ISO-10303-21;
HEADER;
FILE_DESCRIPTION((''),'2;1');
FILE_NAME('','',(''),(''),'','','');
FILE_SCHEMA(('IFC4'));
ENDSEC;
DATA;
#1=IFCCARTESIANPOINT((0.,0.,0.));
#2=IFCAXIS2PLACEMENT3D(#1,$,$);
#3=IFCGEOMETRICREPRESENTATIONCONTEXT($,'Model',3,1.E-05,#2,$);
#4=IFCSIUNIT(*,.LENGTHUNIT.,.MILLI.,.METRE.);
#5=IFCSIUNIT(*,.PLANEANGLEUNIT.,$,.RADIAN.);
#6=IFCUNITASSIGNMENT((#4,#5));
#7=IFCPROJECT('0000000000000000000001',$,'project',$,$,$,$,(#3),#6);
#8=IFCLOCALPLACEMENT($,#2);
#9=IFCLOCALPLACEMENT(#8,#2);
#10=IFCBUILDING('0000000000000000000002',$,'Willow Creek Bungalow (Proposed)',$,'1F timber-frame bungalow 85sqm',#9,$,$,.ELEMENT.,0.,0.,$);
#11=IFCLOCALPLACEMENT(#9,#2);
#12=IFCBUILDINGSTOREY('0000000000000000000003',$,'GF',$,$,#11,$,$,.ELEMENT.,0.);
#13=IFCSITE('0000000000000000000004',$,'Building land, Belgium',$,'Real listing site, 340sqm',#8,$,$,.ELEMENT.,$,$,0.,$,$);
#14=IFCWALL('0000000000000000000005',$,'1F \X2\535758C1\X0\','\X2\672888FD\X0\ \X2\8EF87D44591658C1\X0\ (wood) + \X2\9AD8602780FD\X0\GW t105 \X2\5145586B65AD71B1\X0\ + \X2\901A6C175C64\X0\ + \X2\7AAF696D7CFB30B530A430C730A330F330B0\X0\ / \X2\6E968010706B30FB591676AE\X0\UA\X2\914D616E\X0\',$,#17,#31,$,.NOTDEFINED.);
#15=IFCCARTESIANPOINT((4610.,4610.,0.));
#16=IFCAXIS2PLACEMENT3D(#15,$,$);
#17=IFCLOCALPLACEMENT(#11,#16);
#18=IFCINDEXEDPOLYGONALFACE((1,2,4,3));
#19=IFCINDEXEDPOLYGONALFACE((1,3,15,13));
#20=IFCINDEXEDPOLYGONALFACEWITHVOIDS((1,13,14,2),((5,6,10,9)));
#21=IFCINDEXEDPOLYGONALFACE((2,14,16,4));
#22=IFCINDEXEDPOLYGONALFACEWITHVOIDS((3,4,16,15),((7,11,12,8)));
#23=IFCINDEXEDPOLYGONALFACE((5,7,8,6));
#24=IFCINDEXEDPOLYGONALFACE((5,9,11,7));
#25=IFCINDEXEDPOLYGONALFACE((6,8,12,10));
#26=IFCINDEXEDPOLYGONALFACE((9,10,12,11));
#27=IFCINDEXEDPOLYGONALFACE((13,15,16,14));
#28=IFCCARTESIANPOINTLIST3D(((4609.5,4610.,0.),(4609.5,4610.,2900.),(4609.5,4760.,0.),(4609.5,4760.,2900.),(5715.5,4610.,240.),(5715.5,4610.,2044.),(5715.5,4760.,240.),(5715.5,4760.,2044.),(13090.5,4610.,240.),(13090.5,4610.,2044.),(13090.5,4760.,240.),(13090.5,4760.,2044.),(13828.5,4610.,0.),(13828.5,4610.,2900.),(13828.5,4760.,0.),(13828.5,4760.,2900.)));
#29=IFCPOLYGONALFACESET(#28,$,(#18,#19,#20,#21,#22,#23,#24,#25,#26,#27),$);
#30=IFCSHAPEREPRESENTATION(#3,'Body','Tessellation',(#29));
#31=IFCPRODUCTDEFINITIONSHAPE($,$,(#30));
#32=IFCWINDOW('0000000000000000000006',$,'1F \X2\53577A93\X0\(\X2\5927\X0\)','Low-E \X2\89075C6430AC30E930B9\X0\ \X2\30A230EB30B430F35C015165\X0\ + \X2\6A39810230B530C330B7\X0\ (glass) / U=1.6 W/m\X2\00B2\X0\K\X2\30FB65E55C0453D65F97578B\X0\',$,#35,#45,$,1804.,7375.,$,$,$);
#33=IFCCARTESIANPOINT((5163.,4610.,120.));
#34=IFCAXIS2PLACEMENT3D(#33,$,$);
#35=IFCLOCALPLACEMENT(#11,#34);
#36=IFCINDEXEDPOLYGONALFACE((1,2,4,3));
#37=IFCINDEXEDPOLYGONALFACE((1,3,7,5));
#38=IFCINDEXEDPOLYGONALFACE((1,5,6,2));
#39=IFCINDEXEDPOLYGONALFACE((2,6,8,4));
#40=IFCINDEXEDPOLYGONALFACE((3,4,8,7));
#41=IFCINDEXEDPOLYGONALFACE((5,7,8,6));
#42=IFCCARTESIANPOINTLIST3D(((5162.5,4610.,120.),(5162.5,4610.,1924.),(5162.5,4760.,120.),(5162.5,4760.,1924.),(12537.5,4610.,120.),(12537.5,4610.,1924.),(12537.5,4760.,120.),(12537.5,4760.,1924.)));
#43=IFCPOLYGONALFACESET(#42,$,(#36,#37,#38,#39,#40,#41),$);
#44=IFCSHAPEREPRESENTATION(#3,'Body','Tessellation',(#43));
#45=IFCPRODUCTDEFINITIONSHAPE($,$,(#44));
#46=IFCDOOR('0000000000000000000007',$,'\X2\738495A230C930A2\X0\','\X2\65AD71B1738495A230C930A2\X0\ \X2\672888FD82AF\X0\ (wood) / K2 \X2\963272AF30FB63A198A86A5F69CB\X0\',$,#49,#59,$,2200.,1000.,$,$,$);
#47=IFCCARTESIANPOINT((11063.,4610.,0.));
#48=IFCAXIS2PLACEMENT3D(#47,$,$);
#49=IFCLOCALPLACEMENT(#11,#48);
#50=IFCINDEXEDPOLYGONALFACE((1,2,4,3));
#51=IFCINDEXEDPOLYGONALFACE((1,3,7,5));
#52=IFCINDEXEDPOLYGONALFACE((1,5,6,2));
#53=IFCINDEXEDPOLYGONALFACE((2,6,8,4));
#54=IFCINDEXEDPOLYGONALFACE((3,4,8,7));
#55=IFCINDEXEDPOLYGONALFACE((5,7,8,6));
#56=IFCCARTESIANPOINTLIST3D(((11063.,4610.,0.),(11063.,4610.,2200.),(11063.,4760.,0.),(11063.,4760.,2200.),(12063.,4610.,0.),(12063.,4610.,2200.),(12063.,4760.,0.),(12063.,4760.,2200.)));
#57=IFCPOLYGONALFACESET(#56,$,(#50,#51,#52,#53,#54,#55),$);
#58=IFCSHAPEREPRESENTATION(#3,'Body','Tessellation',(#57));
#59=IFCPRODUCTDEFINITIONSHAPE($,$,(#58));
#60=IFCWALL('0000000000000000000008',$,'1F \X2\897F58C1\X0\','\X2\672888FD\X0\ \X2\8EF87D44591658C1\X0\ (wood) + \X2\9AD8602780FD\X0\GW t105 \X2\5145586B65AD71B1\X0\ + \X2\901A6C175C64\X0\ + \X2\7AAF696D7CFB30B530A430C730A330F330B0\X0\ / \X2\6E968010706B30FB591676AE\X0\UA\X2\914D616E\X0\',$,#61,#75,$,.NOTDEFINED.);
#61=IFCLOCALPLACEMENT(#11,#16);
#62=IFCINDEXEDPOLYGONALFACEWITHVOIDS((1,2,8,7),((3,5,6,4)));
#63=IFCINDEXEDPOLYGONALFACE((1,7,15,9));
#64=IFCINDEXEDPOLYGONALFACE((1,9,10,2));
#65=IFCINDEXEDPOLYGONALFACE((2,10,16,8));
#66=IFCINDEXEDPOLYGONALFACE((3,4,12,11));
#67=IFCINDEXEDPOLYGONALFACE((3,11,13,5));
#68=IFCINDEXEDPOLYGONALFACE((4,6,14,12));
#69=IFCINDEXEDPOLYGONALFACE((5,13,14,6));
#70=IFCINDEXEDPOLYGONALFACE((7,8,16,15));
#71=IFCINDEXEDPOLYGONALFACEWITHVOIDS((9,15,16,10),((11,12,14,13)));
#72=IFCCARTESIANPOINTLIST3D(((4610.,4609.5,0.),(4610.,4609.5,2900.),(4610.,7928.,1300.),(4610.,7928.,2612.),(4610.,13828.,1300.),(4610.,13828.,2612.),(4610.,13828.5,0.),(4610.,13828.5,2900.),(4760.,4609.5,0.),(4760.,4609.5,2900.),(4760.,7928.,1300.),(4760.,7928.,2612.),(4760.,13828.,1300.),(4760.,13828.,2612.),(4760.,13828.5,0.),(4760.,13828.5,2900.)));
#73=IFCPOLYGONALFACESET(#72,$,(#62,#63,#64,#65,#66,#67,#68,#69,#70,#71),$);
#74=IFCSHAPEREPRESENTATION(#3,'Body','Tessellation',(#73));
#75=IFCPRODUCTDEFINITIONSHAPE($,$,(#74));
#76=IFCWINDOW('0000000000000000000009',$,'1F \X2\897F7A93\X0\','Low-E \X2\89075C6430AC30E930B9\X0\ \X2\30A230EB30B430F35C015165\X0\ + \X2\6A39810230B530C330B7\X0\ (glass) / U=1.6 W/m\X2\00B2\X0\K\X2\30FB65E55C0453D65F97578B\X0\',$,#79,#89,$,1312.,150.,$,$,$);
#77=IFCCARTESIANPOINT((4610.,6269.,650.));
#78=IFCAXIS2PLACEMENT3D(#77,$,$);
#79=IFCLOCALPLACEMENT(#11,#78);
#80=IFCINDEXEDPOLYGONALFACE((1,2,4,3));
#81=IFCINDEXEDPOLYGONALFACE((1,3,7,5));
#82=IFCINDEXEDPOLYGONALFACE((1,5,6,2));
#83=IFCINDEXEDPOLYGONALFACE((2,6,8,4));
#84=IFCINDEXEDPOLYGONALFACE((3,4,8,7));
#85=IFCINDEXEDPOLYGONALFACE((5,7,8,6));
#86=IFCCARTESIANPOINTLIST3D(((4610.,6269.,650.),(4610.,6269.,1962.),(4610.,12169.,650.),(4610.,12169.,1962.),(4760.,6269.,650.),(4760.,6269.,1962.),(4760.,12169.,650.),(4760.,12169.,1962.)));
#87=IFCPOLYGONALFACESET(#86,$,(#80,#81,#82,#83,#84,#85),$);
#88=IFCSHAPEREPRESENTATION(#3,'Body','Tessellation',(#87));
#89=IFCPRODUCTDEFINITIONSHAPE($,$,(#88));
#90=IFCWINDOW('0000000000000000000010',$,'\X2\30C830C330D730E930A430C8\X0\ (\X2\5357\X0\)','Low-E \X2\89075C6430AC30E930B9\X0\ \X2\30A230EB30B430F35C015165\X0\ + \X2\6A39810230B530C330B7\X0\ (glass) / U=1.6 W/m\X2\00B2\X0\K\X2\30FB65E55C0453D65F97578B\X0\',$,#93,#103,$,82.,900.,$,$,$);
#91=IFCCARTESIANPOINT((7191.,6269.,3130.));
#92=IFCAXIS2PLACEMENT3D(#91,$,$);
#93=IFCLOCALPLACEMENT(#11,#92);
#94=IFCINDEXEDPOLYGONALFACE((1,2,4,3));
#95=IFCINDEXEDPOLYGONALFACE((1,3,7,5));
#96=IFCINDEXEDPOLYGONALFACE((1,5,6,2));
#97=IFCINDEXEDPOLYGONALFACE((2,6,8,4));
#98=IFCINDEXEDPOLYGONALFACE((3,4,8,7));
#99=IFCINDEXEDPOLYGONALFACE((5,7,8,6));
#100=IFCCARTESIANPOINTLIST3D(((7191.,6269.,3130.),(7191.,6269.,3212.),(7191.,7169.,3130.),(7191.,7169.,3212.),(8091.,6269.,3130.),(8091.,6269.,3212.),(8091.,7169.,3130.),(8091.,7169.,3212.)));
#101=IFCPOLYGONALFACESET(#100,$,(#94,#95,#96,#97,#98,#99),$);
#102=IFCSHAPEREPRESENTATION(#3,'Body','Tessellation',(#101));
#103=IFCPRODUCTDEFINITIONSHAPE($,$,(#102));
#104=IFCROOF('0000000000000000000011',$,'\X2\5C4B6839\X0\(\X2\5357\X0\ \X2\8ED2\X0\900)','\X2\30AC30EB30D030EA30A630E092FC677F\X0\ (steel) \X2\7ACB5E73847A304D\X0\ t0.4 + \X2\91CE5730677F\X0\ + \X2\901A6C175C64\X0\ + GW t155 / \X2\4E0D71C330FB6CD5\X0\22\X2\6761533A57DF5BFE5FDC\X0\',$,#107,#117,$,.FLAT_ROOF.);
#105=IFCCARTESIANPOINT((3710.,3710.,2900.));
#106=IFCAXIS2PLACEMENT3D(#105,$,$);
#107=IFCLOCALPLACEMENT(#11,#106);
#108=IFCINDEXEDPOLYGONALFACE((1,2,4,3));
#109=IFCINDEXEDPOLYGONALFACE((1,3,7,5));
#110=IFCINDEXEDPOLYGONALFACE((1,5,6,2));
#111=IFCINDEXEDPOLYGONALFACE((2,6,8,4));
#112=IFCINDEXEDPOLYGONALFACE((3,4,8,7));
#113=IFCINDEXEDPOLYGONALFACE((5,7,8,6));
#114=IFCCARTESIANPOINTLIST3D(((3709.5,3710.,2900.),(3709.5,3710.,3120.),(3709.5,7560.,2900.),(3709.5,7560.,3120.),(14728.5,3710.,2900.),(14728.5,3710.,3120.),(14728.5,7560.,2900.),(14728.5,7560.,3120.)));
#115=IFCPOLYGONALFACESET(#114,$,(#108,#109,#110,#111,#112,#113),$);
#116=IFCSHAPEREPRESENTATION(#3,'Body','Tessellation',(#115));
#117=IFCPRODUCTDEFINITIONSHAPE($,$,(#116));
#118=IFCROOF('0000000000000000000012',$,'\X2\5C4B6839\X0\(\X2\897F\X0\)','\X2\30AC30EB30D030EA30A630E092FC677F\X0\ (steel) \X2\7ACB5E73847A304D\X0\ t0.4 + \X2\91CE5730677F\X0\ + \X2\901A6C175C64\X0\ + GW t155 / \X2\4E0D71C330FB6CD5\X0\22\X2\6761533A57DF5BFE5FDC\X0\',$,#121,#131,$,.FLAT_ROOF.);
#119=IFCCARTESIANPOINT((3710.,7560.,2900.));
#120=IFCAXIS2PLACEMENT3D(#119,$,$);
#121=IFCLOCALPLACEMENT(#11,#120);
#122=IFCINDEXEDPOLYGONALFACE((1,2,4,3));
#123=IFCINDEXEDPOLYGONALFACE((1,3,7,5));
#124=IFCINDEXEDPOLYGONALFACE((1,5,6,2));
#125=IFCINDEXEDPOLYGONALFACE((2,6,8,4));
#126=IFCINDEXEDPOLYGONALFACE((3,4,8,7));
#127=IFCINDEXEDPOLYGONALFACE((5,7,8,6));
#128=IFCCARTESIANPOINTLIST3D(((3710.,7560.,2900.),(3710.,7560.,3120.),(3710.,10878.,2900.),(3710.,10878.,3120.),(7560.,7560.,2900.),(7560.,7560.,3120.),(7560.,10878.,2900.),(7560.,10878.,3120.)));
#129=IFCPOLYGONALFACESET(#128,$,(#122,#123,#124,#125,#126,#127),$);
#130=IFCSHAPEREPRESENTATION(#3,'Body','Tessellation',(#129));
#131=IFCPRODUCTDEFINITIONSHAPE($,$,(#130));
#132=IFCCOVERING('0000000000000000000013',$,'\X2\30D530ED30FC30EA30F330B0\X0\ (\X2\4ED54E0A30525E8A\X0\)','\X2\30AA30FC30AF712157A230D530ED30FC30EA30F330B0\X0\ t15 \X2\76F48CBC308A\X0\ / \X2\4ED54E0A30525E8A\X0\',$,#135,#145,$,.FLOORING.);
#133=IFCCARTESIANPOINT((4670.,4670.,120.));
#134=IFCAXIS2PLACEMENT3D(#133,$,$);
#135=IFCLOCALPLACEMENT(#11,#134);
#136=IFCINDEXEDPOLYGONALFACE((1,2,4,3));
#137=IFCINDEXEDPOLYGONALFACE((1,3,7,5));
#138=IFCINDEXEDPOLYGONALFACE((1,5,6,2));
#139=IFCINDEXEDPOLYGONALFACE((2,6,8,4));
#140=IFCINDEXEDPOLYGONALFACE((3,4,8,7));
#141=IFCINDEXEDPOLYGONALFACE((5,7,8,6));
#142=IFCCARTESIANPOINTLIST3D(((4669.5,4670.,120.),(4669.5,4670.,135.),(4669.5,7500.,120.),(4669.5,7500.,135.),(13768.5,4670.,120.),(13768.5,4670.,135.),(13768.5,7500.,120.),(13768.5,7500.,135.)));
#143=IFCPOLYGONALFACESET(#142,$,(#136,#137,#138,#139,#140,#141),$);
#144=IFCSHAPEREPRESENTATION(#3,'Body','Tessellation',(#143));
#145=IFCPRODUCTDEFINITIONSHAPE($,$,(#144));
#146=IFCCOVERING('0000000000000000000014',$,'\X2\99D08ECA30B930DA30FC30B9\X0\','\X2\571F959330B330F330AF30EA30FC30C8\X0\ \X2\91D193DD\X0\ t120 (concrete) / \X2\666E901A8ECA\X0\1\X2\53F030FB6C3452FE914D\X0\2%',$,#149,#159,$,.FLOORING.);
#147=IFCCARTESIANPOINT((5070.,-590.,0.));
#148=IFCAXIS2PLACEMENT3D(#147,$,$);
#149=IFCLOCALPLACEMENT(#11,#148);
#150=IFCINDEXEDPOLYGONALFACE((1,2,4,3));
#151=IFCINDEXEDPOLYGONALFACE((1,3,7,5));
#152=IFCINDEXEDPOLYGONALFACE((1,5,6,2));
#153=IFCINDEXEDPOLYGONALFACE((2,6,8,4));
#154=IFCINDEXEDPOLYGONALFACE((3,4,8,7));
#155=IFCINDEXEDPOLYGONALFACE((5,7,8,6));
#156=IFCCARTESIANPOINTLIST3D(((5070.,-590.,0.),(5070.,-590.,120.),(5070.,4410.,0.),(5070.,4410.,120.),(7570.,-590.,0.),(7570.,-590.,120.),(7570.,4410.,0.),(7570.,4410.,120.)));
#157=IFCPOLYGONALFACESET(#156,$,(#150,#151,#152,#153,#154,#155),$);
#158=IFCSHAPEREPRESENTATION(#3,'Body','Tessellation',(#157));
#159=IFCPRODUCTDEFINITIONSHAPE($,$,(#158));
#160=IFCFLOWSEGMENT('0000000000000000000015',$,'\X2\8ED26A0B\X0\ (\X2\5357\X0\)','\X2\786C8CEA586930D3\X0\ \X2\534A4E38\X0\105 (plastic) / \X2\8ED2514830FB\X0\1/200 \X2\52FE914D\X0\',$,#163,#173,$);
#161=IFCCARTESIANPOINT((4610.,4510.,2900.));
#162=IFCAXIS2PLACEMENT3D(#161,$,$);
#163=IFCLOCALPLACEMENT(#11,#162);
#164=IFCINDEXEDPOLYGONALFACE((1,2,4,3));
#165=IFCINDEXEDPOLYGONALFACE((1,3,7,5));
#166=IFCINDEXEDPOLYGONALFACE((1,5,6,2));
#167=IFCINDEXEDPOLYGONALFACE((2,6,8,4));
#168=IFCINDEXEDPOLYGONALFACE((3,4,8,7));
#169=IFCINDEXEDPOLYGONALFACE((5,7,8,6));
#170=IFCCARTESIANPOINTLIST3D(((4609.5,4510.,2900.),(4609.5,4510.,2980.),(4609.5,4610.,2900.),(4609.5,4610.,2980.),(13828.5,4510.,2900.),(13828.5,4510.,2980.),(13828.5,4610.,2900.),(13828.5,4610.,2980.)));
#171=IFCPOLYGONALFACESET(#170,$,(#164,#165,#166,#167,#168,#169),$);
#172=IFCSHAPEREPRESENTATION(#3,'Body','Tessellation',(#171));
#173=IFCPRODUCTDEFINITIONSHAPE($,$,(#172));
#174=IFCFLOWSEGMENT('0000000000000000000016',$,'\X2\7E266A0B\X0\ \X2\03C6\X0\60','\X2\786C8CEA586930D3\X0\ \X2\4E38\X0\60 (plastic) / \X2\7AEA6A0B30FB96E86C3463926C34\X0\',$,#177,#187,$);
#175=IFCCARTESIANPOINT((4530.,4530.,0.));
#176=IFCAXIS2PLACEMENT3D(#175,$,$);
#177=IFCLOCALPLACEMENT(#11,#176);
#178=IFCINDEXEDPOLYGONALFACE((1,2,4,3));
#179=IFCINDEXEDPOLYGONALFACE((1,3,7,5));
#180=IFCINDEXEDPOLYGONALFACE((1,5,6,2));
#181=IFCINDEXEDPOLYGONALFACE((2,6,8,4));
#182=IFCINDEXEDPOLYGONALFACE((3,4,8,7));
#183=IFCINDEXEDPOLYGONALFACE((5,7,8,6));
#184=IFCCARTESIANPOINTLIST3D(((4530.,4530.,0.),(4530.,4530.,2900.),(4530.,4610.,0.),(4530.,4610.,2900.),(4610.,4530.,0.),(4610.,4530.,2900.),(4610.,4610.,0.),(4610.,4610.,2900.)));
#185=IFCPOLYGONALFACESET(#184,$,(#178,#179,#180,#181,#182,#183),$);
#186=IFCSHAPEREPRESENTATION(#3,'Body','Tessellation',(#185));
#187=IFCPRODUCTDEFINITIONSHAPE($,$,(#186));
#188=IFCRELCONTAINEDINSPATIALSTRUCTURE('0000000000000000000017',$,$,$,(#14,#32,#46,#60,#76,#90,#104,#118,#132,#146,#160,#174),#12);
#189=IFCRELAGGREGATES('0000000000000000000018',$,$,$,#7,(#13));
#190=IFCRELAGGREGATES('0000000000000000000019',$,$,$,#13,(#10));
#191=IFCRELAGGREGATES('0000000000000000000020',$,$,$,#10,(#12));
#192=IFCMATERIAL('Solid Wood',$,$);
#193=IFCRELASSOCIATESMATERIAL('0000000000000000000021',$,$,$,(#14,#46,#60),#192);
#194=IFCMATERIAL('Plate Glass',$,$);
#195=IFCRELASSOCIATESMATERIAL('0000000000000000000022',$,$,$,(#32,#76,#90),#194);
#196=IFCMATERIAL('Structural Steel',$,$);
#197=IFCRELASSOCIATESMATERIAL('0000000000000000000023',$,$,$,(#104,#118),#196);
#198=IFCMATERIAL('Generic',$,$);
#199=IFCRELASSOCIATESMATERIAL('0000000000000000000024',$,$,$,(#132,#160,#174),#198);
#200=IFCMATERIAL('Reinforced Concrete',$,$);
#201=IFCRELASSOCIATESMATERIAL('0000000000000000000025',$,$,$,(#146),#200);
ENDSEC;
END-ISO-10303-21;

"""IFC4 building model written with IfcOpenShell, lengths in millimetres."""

from ifc_helpers import new_model, si_unit, frame, frame_2d, origin, place, context, project, spatial, rectangle, extrude, material, element, fill, save


model = new_model("IFC4")

# Units and contexts
model_context = context("Model", 3, precision=1e-05, world=origin())
ifc_project = project(units=[si_unit("LENGTHUNIT", "METRE", prefix="MILLI"), si_unit("PLANEANGLEUNIT", "RADIAN")], contexts=[model_context])

# Site, building, storey
site_placement = place(None, origin())
site = spatial("IfcSite", under=ifc_project, at=site_placement, Name="Building land, Belgium", ObjectType="Real listing site, 340sqm", CompositionType="ELEMENT", RefElevation=0.0)
building_placement = place(site_placement, origin())
building = spatial("IfcBuilding", under=site, at=building_placement, Name="Willow Creek Bungalow (Proposed)", ObjectType="1F timber-frame bungalow 85sqm", CompositionType="ELEMENT", ElevationOfRefHeight=0.0, ElevationOfTerrain=0.0)
storey_placement = place(building_placement, origin())
storey = spatial("IfcBuildingStorey", under=building, at=storey_placement, Name="GF", CompositionType="ELEMENT", Elevation=0.0)

# Shared definitions
ifc_material_1 = material(Name="Solid Wood")

# Shared definitions
ifc_material_2 = material(Name="Reinforced Concrete")

# Wall, openings, window, door
wall_1_placement = place(storey_placement, frame((4610.0, 4610.0, 0.0)))
wall_1 = element("IfcWall", 1, at=wall_1_placement, inside=storey, material=ifc_material_1, Name="1F 南壁", Description="木製 軸組外壁 (wood) + 高性能GW t105 充填断熱 + 通気層 + 窯業系サイディング / 準耐火・外皮UA配慮", PredefinedType="NOTDEFINED", context=model_context, shape_type="SweptSolid", body=[
    extrude(rectangle(XDim=9219.0, YDim=150.0, at=frame_2d((4609.0, 75.0))), frame((4610.0, 4610.0, 0.0)), (0.0, 0.0, 1.0), 2900.0),
])
opening_1_placement = place(storey_placement, frame((5163.0, 4610.0, 120.0)))
opening_1 = element("IfcOpeningElement", 2, at=opening_1_placement, cuts=wall_1, PredefinedType="NOTDEFINED", context=model_context, shape_type="SweptSolid", body=[
    extrude(rectangle(XDim=7375.0, YDim=150.0, at=frame_2d((3687.0, 75.0))), frame((5163.0, 4610.0, 120.0)), (0.0, 0.0, 1.0), 1804.0),
])
opening_2_placement = place(storey_placement, frame((11063.0, 4610.0, 0.0)))
opening_2 = element("IfcOpeningElement", 3, at=opening_2_placement, cuts=wall_1, PredefinedType="NOTDEFINED", context=model_context, shape_type="SweptSolid", body=[
    extrude(rectangle(XDim=1000.0, YDim=150.0, at=frame_2d((500.0, 75.0))), frame((11063.0, 4610.0, 0.0)), (0.0, 0.0, 1.0), 2200.0),
])
ifc_material_3 = material(Name="Plate Glass")
window_1_placement = place(storey_placement, frame((5163.0, 4610.0, 120.0)))
window_1 = element("IfcWindow", 4, at=window_1_placement, inside=storey, material=ifc_material_3, Name="1F 南窓(大)", Description="Low-E 複層ガラス アルゴン封入 + 樹脂サッシ (glass) / U=1.6 W/m²K・日射取得型", OverallHeight=1804.0, OverallWidth=7375.0, context=model_context, shape_type="SweptSolid", body=[
    extrude(rectangle(XDim=7375.0, YDim=150.0, at=frame_2d((3687.0, 75.0))), frame((5163.0, 4610.0, 120.0)), (0.0, 0.0, 1.0), 1804.0),
])
fill(opening_1, window_1)
door_placement = place(storey_placement, frame((11063.0, 4610.0, 0.0)))
door = element("IfcDoor", 5, at=door_placement, inside=storey, material=ifc_material_1, Name="玄関ドア", Description="断熱玄関ドア 木製芯 (wood) / K2 防犯・採風機構", OverallHeight=2200.0, OverallWidth=1000.0, context=model_context, shape_type="SweptSolid", body=[
    extrude(rectangle(XDim=1000.0, YDim=150.0, at=frame_2d((500.0, 75.0))), frame((11063.0, 4610.0, 0.0)), (0.0, 0.0, 1.0), 2200.0),
])
fill(opening_2, door)

# Wall, opening, window
wall_2_placement = place(storey_placement, frame((4610.0, 4610.0, 0.0)))
wall_2 = element("IfcWall", 6, at=wall_2_placement, inside=storey, material=ifc_material_1, Name="1F 西壁", Description="木製 軸組外壁 (wood) + 高性能GW t105 充填断熱 + 通気層 + 窯業系サイディング / 準耐火・外皮UA配慮", PredefinedType="NOTDEFINED", context=model_context, shape_type="SweptSolid", body=[
    extrude(rectangle(XDim=150.0, YDim=9219.0, at=frame_2d((75.0, 4609.0))), frame((4610.0, 4610.0, 0.0)), (0.0, 0.0, 1.0), 2900.0),
])
opening_3_placement = place(storey_placement, frame((4610.0, 6269.0, 650.0)))
opening_3 = element("IfcOpeningElement", 7, at=opening_3_placement, cuts=wall_2, PredefinedType="NOTDEFINED", context=model_context, shape_type="SweptSolid", body=[
    extrude(rectangle(XDim=150.0, YDim=5900.0, at=frame_2d((75.0, 2950.0))), frame((4610.0, 6269.0, 650.0)), (0.0, 0.0, 1.0), 1312.0),
])
window_2_placement = place(storey_placement, frame((4610.0, 6269.0, 650.0)))
window_2 = element("IfcWindow", 8, at=window_2_placement, inside=storey, material=ifc_material_3, Name="1F 西窓", Description="Low-E 複層ガラス アルゴン封入 + 樹脂サッシ (glass) / U=1.6 W/m²K・日射取得型", OverallHeight=1312.0, OverallWidth=150.0, context=model_context, shape_type="SweptSolid", body=[
    extrude(rectangle(XDim=150.0, YDim=5900.0, at=frame_2d((75.0, 2950.0))), frame((4610.0, 6269.0, 650.0)), (0.0, 0.0, 1.0), 1312.0),
])
fill(opening_3, window_2)

# Window
window_3_placement = place(storey_placement, frame((7191.0, 6269.0, 3130.0)))
element("IfcWindow", 9, at=window_3_placement, inside=storey, material=ifc_material_3, Name="トップライト (南)", Description="Low-E 複層ガラス アルゴン封入 + 樹脂サッシ (glass) / U=1.6 W/m²K・日射取得型", OverallHeight=82.0, OverallWidth=900.0, context=model_context, shape_type="SweptSolid", body=[
    extrude(rectangle(XDim=900.0, YDim=900.0, at=frame_2d((450.0, 450.0))), frame((7191.0, 6269.0, 3130.0)), (0.0, 0.0, 1.0), 82.0),
])

# Roofs
ifc_material_4 = material(Name="Structural Steel")
roof_1_placement = place(storey_placement, frame((3710.0, 3710.0, 2900.0)))
element("IfcRoof", 10, at=roof_1_placement, inside=storey, material=ifc_material_4, Name="屋根(南 軒900)", Description="ガルバリウム鋼板 (steel) 立平葺き t0.4 + 野地板 + 通気層 + GW t155 / 不燃・法22条区域対応", PredefinedType="FLAT_ROOF", context=model_context, shape_type="SweptSolid", body=[
    extrude(rectangle(XDim=11019.0, YDim=3850.0, at=frame_2d((5509.0, 1925.0))), frame((3710.0, 3710.0, 2900.0)), (0.0, 0.0, 1.0), 220.0),
])
roof_2_placement = place(storey_placement, frame((3710.0, 7560.0, 2900.0)))
element("IfcRoof", 11, at=roof_2_placement, inside=storey, material=ifc_material_4, Name="屋根(西)", Description="ガルバリウム鋼板 (steel) 立平葺き t0.4 + 野地板 + 通気層 + GW t155 / 不燃・法22条区域対応", PredefinedType="FLAT_ROOF", context=model_context, shape_type="SweptSolid", body=[
    extrude(rectangle(XDim=3850.0, YDim=3318.0, at=frame_2d((1925.0, 1659.0))), frame((3710.0, 7560.0, 2900.0)), (0.0, 0.0, 1.0), 220.0),
])

# Coverings
ifc_material_5 = material(Name="Generic")
covering_1_placement = place(storey_placement, frame((4670.0, 4670.0, 120.0)))
element("IfcCovering", 12, at=covering_1_placement, inside=storey, material=ifc_material_5, Name="フローリング (仕上げ床)", Description="オーク無垢フローリング t15 直貼り / 仕上げ床", PredefinedType="FLOORING", context=model_context, shape_type="SweptSolid", body=[
    extrude(rectangle(XDim=9099.0, YDim=2830.0, at=frame_2d((4549.0, 1415.0))), frame((4670.0, 4670.0, 120.0)), (0.0, 0.0, 1.0), 15.0),
])
covering_2_placement = place(storey_placement, frame((5070.0, -590.0, 0.0)))
element("IfcCovering", 13, at=covering_2_placement, inside=storey, material=ifc_material_2, Name="駐車スペース", Description="土間コンクリート 金鏝 t120 (concrete) / 普通車1台・水勾配2%", PredefinedType="FLOORING", context=model_context, shape_type="SweptSolid", body=[
    extrude(rectangle(XDim=2500.0, YDim=5000.0, at=frame_2d((1250.0, 2500.0))), frame((5070.0, -590.0, 0.0)), (0.0, 0.0, 1.0), 120.0),
])

# Flow segments
flow_segment_1_placement = place(storey_placement, frame((4610.0, 4510.0, 2900.0)))
element("IfcFlowSegment", 14, at=flow_segment_1_placement, inside=storey, material=ifc_material_5, Name="軒樋 (南)", Description="硬質塩ビ 半丸105 (plastic) / 軒先・1/200 勾配", context=model_context, shape_type="SweptSolid", body=[
    extrude(rectangle(XDim=9219.0, YDim=100.0, at=frame_2d((4609.0, 50.0))), frame((4610.0, 4510.0, 2900.0)), (0.0, 0.0, 1.0), 80.0),
])
flow_segment_2_placement = place(storey_placement, frame((4530.0, 4530.0, 0.0)))
element("IfcFlowSegment", 15, at=flow_segment_2_placement, inside=storey, material=ifc_material_5, Name="縦樋 φ60", Description="硬質塩ビ 丸60 (plastic) / 竪樋・雨水排水", context=model_context, shape_type="SweptSolid", body=[
    extrude(rectangle(XDim=80.0, YDim=80.0, at=frame_2d((40.0, 40.0))), frame((4530.0, 4530.0, 0.0)), (0.0, 0.0, 1.0), 2900.0),
])

save(model, "model.ifc")
